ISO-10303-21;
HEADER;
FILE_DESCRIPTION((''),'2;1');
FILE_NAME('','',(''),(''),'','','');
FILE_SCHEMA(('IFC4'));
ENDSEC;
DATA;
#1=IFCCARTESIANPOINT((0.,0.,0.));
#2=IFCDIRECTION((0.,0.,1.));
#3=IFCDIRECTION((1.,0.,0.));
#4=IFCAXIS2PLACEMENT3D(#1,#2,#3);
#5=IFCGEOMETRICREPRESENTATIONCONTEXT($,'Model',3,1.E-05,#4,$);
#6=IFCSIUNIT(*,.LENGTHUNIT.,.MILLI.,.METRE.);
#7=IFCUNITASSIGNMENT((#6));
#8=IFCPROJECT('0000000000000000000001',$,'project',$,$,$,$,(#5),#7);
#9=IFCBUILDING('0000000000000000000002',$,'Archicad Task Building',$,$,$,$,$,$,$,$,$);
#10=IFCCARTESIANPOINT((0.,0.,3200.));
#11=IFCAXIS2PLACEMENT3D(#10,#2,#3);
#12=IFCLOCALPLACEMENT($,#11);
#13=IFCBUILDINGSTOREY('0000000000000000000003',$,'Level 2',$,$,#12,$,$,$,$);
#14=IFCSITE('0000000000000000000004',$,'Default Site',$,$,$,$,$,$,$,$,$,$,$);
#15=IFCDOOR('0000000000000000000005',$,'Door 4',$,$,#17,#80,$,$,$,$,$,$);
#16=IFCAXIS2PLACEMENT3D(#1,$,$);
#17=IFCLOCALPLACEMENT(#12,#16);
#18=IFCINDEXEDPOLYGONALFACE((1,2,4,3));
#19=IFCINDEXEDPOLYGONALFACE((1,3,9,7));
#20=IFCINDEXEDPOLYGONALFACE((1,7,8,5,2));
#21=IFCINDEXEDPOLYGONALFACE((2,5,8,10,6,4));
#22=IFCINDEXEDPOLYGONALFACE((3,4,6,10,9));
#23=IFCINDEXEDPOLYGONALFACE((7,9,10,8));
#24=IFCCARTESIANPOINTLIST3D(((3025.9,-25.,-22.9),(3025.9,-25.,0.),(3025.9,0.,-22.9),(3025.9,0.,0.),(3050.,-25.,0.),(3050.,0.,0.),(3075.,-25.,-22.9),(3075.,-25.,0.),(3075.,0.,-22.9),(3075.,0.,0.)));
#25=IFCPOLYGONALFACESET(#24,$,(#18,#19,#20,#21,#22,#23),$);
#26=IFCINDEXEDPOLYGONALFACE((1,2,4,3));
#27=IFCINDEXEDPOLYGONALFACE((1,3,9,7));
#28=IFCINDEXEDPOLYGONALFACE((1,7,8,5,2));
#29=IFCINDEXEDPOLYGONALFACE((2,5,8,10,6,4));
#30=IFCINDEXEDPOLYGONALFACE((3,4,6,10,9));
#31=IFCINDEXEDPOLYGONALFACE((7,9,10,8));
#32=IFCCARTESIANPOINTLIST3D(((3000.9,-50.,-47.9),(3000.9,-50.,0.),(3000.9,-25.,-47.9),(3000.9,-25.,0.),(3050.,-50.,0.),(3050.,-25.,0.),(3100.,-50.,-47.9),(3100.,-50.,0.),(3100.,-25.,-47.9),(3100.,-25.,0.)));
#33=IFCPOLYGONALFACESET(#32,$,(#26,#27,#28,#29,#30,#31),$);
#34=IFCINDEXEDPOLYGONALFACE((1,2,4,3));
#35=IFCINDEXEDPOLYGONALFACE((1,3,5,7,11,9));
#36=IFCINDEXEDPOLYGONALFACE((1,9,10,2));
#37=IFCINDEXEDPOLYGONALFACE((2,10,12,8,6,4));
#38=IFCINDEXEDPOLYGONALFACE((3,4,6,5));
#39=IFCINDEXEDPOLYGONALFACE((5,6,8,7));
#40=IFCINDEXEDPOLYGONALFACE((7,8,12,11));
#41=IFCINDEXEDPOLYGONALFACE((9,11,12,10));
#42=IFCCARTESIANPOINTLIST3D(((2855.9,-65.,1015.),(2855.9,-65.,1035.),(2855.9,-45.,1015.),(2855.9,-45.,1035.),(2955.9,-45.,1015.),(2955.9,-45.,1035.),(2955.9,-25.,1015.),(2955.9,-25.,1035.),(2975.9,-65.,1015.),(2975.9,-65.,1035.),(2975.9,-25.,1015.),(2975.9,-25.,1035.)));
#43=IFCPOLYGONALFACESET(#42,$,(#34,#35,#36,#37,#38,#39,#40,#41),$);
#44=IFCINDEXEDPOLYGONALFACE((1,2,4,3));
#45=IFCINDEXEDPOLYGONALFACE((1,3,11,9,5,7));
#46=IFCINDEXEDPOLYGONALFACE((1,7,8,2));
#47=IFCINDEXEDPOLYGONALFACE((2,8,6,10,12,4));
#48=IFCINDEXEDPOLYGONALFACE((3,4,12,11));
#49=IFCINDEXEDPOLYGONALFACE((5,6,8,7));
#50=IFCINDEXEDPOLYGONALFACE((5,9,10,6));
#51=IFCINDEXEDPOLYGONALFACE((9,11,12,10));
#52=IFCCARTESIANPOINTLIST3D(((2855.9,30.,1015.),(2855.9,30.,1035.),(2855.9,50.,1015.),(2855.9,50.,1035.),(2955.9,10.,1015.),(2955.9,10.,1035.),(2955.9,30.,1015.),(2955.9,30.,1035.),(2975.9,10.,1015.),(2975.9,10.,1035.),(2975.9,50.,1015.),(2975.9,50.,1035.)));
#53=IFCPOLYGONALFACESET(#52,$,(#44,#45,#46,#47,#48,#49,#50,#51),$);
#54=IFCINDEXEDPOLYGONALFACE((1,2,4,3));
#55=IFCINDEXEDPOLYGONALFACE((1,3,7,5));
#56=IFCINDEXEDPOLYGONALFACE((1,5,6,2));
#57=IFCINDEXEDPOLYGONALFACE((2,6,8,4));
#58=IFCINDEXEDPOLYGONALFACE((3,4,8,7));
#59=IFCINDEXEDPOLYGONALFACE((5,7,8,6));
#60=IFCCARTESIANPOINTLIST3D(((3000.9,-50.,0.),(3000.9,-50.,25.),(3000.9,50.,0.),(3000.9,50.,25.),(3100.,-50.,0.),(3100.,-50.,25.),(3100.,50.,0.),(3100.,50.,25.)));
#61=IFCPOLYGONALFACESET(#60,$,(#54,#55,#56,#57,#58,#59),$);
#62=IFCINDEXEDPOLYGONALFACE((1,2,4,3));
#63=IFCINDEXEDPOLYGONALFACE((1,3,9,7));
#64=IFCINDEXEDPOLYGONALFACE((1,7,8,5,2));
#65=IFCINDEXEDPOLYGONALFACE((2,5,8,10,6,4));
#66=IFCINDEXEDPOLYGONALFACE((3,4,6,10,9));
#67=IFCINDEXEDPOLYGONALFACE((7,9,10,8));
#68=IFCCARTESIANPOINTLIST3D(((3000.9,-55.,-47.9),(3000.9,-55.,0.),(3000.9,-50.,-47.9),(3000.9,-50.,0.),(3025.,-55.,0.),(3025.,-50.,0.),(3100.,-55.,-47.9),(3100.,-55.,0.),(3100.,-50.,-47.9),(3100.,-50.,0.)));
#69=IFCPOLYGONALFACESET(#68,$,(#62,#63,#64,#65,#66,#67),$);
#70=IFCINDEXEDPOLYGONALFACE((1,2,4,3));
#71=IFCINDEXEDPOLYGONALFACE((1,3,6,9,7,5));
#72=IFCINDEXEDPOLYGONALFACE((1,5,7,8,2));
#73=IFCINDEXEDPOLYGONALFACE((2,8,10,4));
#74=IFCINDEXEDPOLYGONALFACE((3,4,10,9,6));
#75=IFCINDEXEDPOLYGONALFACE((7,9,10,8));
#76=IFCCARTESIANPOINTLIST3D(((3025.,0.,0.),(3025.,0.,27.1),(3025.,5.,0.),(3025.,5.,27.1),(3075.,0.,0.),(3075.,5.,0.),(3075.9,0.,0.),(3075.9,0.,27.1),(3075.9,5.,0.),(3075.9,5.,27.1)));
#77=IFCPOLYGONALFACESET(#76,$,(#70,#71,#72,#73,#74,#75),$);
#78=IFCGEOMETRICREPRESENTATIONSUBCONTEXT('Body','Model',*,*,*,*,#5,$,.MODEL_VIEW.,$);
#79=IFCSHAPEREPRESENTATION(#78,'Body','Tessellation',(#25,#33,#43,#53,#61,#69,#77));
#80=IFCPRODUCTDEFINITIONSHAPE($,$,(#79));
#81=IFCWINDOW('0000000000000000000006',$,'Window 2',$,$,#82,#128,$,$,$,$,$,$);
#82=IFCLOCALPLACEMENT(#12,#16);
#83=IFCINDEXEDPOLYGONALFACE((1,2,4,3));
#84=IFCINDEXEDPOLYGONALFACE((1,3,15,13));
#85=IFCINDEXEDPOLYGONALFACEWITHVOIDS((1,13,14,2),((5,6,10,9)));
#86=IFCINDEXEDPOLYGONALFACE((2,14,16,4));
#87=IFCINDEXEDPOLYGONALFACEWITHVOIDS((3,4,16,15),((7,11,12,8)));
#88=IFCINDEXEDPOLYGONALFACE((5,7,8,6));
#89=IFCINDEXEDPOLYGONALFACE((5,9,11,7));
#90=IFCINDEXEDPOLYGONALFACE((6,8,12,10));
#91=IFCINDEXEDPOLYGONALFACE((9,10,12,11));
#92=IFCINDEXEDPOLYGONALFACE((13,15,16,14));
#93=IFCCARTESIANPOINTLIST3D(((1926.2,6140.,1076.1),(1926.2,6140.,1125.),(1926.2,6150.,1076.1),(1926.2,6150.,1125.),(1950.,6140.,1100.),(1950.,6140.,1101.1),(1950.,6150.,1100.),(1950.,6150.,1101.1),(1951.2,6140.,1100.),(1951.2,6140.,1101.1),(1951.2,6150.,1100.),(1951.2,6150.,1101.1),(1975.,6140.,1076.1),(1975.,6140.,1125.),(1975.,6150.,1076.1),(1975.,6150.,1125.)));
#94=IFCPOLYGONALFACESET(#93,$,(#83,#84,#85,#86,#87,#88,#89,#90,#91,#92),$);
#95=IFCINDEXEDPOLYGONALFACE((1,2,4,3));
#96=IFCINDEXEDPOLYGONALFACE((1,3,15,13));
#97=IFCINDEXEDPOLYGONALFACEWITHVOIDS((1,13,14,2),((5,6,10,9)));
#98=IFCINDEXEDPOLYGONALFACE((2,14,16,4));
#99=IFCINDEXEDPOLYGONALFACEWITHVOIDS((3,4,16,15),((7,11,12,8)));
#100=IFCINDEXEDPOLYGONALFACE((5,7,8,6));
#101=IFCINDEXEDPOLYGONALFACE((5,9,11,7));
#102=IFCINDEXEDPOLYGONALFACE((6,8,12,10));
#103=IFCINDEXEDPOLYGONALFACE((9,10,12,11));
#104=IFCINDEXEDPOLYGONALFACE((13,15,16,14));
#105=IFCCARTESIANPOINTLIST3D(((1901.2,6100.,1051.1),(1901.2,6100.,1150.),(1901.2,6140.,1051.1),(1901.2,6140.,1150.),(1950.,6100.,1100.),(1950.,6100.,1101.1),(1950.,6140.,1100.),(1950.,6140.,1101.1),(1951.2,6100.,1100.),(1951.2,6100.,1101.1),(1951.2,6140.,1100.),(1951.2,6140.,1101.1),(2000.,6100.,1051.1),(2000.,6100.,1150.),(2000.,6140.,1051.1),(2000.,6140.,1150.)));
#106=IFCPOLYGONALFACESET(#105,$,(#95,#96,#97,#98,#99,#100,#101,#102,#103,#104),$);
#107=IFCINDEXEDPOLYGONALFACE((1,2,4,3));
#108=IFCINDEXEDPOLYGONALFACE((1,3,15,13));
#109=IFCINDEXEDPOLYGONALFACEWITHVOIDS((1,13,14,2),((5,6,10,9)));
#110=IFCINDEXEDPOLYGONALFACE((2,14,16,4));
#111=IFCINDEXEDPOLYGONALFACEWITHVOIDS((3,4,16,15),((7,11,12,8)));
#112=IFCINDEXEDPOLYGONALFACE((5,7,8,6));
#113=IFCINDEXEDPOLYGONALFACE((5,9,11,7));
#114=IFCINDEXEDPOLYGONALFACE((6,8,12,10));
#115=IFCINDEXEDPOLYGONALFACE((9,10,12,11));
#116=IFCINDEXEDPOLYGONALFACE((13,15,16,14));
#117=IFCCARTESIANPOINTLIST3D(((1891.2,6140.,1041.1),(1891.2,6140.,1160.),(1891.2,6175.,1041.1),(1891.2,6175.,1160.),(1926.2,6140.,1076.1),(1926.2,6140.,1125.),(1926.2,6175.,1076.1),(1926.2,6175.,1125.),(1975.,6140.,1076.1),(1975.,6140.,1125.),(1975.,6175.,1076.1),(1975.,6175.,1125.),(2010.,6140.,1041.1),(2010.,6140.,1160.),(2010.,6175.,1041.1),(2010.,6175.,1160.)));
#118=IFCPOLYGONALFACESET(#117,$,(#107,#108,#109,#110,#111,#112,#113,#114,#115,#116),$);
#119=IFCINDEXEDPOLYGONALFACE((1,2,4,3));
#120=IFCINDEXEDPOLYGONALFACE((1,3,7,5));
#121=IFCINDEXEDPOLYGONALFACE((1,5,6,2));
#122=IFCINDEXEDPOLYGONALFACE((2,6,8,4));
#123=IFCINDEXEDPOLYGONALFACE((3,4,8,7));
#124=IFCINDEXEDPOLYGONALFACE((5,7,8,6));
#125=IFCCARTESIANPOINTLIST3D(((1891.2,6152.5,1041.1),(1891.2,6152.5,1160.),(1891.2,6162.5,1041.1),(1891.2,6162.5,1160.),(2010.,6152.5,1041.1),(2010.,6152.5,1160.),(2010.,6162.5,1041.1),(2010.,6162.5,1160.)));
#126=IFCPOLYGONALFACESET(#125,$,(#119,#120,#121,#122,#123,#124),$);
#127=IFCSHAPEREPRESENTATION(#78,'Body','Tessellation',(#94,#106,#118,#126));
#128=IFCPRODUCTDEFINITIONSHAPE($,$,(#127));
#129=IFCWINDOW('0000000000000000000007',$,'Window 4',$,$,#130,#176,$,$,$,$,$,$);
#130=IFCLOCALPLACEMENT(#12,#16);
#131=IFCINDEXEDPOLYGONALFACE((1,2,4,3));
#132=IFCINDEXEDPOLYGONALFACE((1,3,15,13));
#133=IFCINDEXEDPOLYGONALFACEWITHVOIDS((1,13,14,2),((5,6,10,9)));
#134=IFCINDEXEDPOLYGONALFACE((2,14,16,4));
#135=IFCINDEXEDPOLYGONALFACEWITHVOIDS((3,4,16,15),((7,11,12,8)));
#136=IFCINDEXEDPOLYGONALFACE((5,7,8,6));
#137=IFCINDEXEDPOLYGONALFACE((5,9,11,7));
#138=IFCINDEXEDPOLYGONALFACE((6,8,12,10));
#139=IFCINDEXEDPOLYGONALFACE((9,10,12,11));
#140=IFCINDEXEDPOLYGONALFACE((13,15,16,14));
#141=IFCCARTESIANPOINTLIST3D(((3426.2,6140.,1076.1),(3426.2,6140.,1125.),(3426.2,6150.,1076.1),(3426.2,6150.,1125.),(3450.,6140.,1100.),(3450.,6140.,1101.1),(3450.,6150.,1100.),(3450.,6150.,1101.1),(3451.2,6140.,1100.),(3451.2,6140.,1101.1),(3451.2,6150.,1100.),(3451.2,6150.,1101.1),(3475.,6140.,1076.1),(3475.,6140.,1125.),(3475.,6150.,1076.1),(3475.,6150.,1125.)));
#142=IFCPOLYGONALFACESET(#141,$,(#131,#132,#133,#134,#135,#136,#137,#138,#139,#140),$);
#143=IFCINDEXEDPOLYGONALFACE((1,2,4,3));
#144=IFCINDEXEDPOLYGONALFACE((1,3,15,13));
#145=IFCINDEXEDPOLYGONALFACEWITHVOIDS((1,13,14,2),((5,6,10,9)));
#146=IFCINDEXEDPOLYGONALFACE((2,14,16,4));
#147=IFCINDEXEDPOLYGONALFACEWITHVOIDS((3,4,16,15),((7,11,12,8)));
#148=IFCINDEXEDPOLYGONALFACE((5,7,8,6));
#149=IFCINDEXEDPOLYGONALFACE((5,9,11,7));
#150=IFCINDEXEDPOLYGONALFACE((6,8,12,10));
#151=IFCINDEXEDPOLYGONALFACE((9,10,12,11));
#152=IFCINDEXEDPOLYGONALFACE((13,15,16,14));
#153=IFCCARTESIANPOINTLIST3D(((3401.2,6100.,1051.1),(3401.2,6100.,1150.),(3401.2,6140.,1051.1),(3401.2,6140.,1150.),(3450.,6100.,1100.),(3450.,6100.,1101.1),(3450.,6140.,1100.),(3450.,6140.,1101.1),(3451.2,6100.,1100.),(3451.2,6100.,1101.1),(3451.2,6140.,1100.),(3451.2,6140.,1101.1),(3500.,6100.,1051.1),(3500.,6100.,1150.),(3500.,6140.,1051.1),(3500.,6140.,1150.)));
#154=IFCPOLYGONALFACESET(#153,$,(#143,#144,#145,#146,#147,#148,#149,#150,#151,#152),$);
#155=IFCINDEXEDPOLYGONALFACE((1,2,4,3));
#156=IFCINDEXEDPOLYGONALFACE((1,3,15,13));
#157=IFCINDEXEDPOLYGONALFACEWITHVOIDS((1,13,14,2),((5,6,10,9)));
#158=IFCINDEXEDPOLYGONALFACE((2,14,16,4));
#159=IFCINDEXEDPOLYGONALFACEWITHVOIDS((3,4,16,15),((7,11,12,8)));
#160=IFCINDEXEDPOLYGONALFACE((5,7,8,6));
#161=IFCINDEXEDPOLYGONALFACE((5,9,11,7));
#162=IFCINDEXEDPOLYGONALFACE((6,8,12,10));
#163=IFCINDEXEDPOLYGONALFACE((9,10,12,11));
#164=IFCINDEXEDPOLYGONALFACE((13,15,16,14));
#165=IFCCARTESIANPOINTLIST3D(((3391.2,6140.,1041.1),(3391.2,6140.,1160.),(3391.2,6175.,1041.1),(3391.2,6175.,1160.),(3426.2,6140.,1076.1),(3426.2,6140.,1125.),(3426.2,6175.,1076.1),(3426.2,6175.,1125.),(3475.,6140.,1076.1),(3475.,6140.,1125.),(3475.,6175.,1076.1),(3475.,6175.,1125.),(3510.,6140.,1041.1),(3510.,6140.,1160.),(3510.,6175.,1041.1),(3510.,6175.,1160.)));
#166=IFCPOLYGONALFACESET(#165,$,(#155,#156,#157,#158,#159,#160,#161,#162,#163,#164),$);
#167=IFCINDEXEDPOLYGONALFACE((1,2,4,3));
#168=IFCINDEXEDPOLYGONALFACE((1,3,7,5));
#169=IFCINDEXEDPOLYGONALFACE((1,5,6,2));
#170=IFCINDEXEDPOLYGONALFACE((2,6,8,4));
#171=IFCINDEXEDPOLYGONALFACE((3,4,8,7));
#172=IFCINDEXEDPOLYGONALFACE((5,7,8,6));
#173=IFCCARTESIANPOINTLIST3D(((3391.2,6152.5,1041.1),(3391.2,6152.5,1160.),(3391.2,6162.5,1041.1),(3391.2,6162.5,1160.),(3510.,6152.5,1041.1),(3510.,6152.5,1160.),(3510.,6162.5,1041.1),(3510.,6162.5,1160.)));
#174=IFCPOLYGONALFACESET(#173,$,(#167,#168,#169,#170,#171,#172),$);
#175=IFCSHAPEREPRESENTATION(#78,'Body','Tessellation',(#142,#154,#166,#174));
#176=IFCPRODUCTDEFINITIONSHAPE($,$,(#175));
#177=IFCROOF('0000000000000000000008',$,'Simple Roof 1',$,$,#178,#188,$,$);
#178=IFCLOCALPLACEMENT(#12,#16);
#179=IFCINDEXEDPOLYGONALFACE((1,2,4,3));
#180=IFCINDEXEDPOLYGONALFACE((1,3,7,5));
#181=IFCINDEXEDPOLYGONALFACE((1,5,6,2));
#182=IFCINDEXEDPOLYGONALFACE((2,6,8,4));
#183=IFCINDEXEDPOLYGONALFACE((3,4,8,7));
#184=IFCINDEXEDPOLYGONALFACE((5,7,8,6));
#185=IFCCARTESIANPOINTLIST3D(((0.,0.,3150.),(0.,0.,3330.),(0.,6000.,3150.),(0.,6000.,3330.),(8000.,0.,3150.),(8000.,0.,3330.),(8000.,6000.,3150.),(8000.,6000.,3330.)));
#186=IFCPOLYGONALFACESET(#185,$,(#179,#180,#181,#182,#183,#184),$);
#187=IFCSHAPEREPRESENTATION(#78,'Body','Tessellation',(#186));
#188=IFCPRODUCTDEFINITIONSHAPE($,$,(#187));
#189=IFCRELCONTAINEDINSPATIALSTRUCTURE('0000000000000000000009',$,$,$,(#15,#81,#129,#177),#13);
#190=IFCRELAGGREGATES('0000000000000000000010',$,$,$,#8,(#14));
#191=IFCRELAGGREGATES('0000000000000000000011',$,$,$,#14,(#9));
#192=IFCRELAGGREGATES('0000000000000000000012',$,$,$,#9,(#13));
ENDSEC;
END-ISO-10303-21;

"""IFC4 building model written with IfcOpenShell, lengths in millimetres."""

from ifc_helpers import new_model, si_unit, frame, origin_with_axes, place, context, subcontext, project, spatial, line, indexed_curve, outline, extrude, element, save


model = new_model("IFC4")

# Units and contexts
model_context = context("Model", 3, precision=1e-05, world=origin_with_axes())
body_context = subcontext(model_context, "Body", "Model", "MODEL_VIEW")
ifc_project = project(units=[si_unit("LENGTHUNIT", "METRE", prefix="MILLI")], contexts=[model_context])

# Site, building, storey
site = spatial("IfcSite", under=ifc_project, Name="Default Site")
building = spatial("IfcBuilding", under=site, Name="Archicad Task Building")
storey_placement = place(None, frame((0.0, 0.0, 3200.0), z_axis=(0.0, 0.0, 1.0), x_axis=(1.0, 0.0, 0.0)))
storey = spatial("IfcBuildingStorey", under=building, at=storey_placement, Name="Level 2")

# Door
door_1_placement = place(storey_placement, frame((3050.0, -50.0, 0.0), z_axis=(0.0, 0.0, 1.0), x_axis=(1.0, 0.0, 0.0)))
element("IfcDoor", 1, at=door_1_placement, inside=storey, Name="Door 4", context=body_context, shape_type="SweptSolid", body=[
    extrude(outline(indexed_curve([(0.0, 0.0), (0.0, 2.1), (0.9, 2.1), (0.9, 0.0), (-24.1, 0.0), (-24.1, -22.9), (25.0, -22.9), (25.0, 0.0)], segments=[line(1, 2, 3, 4, 5, 6, 7, 8, 1)])), frame((0.0, 25.0, 0.0), z_axis=(0.0, -1.0, 0.0), x_axis=(1.0, 0.0, 0.0)), (0.0, 0.0, -1.0), 25.0),
    extrude(outline(indexed_curve([(0.0, 0.0), (0.0, 2.1), (0.9, 2.1), (0.9, 0.0), (-49.1, 0.0), (-49.1, -47.9), (50.0, -47.9), (50.0, 0.0)], segments=[line(1, 2, 3, 4, 5, 6, 7, 8, 1)])), frame((0.0, 0.0, 0.0), z_axis=(0.0, -1.0, 0.0), x_axis=(1.0, 0.0, 0.0)), (0.0, 0.0, -1.0), 25.0),
    extrude(outline(indexed_curve([(0.0, 0.0), (-49.1, 0.0), (-49.1, 35.0), (0.0, 35.0)], segments=[line(1, 2, 3, 4, 1)])), frame((25.0, 25.0, 25.0), z_axis=(0.0, 0.0, 1.0), x_axis=(1.0, 0.0, 0.0)), (0.0, 0.0, 1.0), -47.9),
    extrude(outline(indexed_curve([(0.0, 0.0), (0.0, -40.0), (-120.0, -40.0), (-120.0, -20.0), (-20.0, -20.0), (-20.0, 0.0)], segments=[line(1, 2, 3, 4, 5, 6, 1)])), frame((-74.1, 25.0, 1015.0), z_axis=(0.0, 0.0, 1.0), x_axis=(1.0, 0.0, 0.0)), (0.0, 0.0, 1.0), 20.0),
    extrude(outline(indexed_curve([(0.0, 0.0), (0.0, 40.0), (-120.0, 40.0), (-120.0, 20.0), (-20.0, 20.0), (-20.0, 0.0)], segments=[line(1, 2, 3, 4, 5, 6, 1)])), frame((-74.1, 60.0, 1015.0), z_axis=(0.0, 0.0, 1.0), x_axis=(1.0, 0.0, 0.0)), (0.0, 0.0, 1.0), 20.0),
    extrude(outline(indexed_curve([(0.0, 0.0), (-99.1, 0.0), (-99.1, 100.0), (0.0, 100.0)], segments=[line(1, 2, 3, 4, 1)])), frame((50.0, 0.0, 0.0), z_axis=(0.0, 0.0, 1.0), x_axis=(1.0, 0.0, 0.0)), (0.0, 0.0, 1.0), 25.0),
    extrude(outline(indexed_curve([(0.0, 0.0), (0.0, 27.1), (50.9, 27.1), (50.9, 0.0), (-24.1, 0.0), (-24.1, -47.9), (75.0, -47.9), (75.0, 0.0)], segments=[line(1, 2, 3, 4, 5, 6, 7, 8, 1)])), frame((-25.0, -5.0, 0.0), z_axis=(0.0, -1.0, 0.0), x_axis=(1.0, 0.0, 0.0)), (0.0, 0.0, -1.0), 5.0),
    extrude(outline(indexed_curve([(0.0, 0.0), (0.0, 27.1), (50.9, 27.1), (50.9, 0.0), (0.9, 0.0), (0.9, -22.9), (50.0, -22.9), (50.0, 0.0)], segments=[line(1, 2, 3, 4, 5, 6, 7, 8, 1)])), frame((-25.0, 50.0, 0.0), z_axis=(0.0, -1.0, 0.0), x_axis=(1.0, 0.0, 0.0)), (0.0, 0.0, -1.0), 5.0),
])

# Windows
for number, where, z_axis, x_axis, name in (
    (2, (1950.0, 6050.0, 1100.0), (0.0, 0.0, 1.0), (1.0, 0.0, 0.0), "Window 2"),
    (3, (3450.0, 6050.0, 1100.0), (0.0, 0.0, 1.0), (1.0, 0.0, 0.0), "Window 4"),
):
    element("IfcWindow", number, at=place(storey_placement, frame(where, z_axis=z_axis, x_axis=x_axis)), inside=storey, Name=name, context=body_context, shape_type="SweptSolid", body=[
        extrude(outline(indexed_curve([(0.0, 0.0), (1.2, 0.0), (1.2, 1.1), (0.0, 1.1)], segments=[line(1, 2, 3, 4, 1)]), holes=[indexed_curve([(25.0, 25.0), (-23.8, 25.0), (-23.8, -23.9), (25.0, -23.9)], segments=[line(1, 2, 3, 4, 1)])]), frame((0.0, 90.0, 0.0), z_axis=(0.0, -1.0, 0.0), x_axis=(1.0, 0.0, 0.0)), (0.0, 0.0, -1.0), 10.0),
        extrude(outline(indexed_curve([(0.0, 0.0), (1.2, 0.0), (1.2, 1.1), (0.0, 1.1)], segments=[line(1, 2, 3, 4, 1)]), holes=[indexed_curve([(50.0, 50.0), (-48.8, 50.0), (-48.8, -48.9), (50.0, -48.9)], segments=[line(1, 2, 3, 4, 1)])]), frame((0.0, 50.0, 0.0), z_axis=(0.0, -1.0, 0.0), x_axis=(1.0, 0.0, 0.0)), (0.0, 0.0, -1.0), 40.0),
        extrude(outline(indexed_curve([(0.0, 0.0), (-48.8, 0.0), (-48.8, -48.9), (0.0, -48.9)], segments=[line(1, 2, 3, 4, 1)]), holes=[indexed_curve([(35.0, 35.0), (-83.8, 35.0), (-83.8, -83.9), (35.0, -83.9)], segments=[line(1, 2, 3, 4, 1)])]), frame((25.0, 90.0, 25.0), z_axis=(0.0, -1.0, 0.0), x_axis=(1.0, 0.0, 0.0)), (0.0, 0.0, -1.0), 35.0),
        extrude(outline(indexed_curve([(35.0, 35.0), (-83.8, 35.0), (-83.8, -83.9), (35.0, -83.9)], segments=[line(1, 2, 3, 4, 1)])), frame((25.0, 102.5, 25.0), z_axis=(0.0, -1.0, 0.0), x_axis=(1.0, 0.0, 0.0)), (0.0, 0.0, -1.0), 10.0),
    ])

# Roof
roof_placement = place(storey_placement, frame((0.0, 0.0, 3150.0), z_axis=(0.0, 0.0, 1.0), x_axis=(1.0, 0.0, 0.0)))
element("IfcRoof", 4, at=roof_placement, inside=storey, Name="Simple Roof 1", context=body_context, shape_type="SweptSolid", body=[
    extrude(outline(indexed_curve([(0.0, 0.0), (8000.0, 0.0), (8000.0, 6000.0), (0.0, 6000.0), (0.0, 0.0)])), None, (0.0, 0.0, 1.0), 180.0),
])

save(model, "model.ifc")
